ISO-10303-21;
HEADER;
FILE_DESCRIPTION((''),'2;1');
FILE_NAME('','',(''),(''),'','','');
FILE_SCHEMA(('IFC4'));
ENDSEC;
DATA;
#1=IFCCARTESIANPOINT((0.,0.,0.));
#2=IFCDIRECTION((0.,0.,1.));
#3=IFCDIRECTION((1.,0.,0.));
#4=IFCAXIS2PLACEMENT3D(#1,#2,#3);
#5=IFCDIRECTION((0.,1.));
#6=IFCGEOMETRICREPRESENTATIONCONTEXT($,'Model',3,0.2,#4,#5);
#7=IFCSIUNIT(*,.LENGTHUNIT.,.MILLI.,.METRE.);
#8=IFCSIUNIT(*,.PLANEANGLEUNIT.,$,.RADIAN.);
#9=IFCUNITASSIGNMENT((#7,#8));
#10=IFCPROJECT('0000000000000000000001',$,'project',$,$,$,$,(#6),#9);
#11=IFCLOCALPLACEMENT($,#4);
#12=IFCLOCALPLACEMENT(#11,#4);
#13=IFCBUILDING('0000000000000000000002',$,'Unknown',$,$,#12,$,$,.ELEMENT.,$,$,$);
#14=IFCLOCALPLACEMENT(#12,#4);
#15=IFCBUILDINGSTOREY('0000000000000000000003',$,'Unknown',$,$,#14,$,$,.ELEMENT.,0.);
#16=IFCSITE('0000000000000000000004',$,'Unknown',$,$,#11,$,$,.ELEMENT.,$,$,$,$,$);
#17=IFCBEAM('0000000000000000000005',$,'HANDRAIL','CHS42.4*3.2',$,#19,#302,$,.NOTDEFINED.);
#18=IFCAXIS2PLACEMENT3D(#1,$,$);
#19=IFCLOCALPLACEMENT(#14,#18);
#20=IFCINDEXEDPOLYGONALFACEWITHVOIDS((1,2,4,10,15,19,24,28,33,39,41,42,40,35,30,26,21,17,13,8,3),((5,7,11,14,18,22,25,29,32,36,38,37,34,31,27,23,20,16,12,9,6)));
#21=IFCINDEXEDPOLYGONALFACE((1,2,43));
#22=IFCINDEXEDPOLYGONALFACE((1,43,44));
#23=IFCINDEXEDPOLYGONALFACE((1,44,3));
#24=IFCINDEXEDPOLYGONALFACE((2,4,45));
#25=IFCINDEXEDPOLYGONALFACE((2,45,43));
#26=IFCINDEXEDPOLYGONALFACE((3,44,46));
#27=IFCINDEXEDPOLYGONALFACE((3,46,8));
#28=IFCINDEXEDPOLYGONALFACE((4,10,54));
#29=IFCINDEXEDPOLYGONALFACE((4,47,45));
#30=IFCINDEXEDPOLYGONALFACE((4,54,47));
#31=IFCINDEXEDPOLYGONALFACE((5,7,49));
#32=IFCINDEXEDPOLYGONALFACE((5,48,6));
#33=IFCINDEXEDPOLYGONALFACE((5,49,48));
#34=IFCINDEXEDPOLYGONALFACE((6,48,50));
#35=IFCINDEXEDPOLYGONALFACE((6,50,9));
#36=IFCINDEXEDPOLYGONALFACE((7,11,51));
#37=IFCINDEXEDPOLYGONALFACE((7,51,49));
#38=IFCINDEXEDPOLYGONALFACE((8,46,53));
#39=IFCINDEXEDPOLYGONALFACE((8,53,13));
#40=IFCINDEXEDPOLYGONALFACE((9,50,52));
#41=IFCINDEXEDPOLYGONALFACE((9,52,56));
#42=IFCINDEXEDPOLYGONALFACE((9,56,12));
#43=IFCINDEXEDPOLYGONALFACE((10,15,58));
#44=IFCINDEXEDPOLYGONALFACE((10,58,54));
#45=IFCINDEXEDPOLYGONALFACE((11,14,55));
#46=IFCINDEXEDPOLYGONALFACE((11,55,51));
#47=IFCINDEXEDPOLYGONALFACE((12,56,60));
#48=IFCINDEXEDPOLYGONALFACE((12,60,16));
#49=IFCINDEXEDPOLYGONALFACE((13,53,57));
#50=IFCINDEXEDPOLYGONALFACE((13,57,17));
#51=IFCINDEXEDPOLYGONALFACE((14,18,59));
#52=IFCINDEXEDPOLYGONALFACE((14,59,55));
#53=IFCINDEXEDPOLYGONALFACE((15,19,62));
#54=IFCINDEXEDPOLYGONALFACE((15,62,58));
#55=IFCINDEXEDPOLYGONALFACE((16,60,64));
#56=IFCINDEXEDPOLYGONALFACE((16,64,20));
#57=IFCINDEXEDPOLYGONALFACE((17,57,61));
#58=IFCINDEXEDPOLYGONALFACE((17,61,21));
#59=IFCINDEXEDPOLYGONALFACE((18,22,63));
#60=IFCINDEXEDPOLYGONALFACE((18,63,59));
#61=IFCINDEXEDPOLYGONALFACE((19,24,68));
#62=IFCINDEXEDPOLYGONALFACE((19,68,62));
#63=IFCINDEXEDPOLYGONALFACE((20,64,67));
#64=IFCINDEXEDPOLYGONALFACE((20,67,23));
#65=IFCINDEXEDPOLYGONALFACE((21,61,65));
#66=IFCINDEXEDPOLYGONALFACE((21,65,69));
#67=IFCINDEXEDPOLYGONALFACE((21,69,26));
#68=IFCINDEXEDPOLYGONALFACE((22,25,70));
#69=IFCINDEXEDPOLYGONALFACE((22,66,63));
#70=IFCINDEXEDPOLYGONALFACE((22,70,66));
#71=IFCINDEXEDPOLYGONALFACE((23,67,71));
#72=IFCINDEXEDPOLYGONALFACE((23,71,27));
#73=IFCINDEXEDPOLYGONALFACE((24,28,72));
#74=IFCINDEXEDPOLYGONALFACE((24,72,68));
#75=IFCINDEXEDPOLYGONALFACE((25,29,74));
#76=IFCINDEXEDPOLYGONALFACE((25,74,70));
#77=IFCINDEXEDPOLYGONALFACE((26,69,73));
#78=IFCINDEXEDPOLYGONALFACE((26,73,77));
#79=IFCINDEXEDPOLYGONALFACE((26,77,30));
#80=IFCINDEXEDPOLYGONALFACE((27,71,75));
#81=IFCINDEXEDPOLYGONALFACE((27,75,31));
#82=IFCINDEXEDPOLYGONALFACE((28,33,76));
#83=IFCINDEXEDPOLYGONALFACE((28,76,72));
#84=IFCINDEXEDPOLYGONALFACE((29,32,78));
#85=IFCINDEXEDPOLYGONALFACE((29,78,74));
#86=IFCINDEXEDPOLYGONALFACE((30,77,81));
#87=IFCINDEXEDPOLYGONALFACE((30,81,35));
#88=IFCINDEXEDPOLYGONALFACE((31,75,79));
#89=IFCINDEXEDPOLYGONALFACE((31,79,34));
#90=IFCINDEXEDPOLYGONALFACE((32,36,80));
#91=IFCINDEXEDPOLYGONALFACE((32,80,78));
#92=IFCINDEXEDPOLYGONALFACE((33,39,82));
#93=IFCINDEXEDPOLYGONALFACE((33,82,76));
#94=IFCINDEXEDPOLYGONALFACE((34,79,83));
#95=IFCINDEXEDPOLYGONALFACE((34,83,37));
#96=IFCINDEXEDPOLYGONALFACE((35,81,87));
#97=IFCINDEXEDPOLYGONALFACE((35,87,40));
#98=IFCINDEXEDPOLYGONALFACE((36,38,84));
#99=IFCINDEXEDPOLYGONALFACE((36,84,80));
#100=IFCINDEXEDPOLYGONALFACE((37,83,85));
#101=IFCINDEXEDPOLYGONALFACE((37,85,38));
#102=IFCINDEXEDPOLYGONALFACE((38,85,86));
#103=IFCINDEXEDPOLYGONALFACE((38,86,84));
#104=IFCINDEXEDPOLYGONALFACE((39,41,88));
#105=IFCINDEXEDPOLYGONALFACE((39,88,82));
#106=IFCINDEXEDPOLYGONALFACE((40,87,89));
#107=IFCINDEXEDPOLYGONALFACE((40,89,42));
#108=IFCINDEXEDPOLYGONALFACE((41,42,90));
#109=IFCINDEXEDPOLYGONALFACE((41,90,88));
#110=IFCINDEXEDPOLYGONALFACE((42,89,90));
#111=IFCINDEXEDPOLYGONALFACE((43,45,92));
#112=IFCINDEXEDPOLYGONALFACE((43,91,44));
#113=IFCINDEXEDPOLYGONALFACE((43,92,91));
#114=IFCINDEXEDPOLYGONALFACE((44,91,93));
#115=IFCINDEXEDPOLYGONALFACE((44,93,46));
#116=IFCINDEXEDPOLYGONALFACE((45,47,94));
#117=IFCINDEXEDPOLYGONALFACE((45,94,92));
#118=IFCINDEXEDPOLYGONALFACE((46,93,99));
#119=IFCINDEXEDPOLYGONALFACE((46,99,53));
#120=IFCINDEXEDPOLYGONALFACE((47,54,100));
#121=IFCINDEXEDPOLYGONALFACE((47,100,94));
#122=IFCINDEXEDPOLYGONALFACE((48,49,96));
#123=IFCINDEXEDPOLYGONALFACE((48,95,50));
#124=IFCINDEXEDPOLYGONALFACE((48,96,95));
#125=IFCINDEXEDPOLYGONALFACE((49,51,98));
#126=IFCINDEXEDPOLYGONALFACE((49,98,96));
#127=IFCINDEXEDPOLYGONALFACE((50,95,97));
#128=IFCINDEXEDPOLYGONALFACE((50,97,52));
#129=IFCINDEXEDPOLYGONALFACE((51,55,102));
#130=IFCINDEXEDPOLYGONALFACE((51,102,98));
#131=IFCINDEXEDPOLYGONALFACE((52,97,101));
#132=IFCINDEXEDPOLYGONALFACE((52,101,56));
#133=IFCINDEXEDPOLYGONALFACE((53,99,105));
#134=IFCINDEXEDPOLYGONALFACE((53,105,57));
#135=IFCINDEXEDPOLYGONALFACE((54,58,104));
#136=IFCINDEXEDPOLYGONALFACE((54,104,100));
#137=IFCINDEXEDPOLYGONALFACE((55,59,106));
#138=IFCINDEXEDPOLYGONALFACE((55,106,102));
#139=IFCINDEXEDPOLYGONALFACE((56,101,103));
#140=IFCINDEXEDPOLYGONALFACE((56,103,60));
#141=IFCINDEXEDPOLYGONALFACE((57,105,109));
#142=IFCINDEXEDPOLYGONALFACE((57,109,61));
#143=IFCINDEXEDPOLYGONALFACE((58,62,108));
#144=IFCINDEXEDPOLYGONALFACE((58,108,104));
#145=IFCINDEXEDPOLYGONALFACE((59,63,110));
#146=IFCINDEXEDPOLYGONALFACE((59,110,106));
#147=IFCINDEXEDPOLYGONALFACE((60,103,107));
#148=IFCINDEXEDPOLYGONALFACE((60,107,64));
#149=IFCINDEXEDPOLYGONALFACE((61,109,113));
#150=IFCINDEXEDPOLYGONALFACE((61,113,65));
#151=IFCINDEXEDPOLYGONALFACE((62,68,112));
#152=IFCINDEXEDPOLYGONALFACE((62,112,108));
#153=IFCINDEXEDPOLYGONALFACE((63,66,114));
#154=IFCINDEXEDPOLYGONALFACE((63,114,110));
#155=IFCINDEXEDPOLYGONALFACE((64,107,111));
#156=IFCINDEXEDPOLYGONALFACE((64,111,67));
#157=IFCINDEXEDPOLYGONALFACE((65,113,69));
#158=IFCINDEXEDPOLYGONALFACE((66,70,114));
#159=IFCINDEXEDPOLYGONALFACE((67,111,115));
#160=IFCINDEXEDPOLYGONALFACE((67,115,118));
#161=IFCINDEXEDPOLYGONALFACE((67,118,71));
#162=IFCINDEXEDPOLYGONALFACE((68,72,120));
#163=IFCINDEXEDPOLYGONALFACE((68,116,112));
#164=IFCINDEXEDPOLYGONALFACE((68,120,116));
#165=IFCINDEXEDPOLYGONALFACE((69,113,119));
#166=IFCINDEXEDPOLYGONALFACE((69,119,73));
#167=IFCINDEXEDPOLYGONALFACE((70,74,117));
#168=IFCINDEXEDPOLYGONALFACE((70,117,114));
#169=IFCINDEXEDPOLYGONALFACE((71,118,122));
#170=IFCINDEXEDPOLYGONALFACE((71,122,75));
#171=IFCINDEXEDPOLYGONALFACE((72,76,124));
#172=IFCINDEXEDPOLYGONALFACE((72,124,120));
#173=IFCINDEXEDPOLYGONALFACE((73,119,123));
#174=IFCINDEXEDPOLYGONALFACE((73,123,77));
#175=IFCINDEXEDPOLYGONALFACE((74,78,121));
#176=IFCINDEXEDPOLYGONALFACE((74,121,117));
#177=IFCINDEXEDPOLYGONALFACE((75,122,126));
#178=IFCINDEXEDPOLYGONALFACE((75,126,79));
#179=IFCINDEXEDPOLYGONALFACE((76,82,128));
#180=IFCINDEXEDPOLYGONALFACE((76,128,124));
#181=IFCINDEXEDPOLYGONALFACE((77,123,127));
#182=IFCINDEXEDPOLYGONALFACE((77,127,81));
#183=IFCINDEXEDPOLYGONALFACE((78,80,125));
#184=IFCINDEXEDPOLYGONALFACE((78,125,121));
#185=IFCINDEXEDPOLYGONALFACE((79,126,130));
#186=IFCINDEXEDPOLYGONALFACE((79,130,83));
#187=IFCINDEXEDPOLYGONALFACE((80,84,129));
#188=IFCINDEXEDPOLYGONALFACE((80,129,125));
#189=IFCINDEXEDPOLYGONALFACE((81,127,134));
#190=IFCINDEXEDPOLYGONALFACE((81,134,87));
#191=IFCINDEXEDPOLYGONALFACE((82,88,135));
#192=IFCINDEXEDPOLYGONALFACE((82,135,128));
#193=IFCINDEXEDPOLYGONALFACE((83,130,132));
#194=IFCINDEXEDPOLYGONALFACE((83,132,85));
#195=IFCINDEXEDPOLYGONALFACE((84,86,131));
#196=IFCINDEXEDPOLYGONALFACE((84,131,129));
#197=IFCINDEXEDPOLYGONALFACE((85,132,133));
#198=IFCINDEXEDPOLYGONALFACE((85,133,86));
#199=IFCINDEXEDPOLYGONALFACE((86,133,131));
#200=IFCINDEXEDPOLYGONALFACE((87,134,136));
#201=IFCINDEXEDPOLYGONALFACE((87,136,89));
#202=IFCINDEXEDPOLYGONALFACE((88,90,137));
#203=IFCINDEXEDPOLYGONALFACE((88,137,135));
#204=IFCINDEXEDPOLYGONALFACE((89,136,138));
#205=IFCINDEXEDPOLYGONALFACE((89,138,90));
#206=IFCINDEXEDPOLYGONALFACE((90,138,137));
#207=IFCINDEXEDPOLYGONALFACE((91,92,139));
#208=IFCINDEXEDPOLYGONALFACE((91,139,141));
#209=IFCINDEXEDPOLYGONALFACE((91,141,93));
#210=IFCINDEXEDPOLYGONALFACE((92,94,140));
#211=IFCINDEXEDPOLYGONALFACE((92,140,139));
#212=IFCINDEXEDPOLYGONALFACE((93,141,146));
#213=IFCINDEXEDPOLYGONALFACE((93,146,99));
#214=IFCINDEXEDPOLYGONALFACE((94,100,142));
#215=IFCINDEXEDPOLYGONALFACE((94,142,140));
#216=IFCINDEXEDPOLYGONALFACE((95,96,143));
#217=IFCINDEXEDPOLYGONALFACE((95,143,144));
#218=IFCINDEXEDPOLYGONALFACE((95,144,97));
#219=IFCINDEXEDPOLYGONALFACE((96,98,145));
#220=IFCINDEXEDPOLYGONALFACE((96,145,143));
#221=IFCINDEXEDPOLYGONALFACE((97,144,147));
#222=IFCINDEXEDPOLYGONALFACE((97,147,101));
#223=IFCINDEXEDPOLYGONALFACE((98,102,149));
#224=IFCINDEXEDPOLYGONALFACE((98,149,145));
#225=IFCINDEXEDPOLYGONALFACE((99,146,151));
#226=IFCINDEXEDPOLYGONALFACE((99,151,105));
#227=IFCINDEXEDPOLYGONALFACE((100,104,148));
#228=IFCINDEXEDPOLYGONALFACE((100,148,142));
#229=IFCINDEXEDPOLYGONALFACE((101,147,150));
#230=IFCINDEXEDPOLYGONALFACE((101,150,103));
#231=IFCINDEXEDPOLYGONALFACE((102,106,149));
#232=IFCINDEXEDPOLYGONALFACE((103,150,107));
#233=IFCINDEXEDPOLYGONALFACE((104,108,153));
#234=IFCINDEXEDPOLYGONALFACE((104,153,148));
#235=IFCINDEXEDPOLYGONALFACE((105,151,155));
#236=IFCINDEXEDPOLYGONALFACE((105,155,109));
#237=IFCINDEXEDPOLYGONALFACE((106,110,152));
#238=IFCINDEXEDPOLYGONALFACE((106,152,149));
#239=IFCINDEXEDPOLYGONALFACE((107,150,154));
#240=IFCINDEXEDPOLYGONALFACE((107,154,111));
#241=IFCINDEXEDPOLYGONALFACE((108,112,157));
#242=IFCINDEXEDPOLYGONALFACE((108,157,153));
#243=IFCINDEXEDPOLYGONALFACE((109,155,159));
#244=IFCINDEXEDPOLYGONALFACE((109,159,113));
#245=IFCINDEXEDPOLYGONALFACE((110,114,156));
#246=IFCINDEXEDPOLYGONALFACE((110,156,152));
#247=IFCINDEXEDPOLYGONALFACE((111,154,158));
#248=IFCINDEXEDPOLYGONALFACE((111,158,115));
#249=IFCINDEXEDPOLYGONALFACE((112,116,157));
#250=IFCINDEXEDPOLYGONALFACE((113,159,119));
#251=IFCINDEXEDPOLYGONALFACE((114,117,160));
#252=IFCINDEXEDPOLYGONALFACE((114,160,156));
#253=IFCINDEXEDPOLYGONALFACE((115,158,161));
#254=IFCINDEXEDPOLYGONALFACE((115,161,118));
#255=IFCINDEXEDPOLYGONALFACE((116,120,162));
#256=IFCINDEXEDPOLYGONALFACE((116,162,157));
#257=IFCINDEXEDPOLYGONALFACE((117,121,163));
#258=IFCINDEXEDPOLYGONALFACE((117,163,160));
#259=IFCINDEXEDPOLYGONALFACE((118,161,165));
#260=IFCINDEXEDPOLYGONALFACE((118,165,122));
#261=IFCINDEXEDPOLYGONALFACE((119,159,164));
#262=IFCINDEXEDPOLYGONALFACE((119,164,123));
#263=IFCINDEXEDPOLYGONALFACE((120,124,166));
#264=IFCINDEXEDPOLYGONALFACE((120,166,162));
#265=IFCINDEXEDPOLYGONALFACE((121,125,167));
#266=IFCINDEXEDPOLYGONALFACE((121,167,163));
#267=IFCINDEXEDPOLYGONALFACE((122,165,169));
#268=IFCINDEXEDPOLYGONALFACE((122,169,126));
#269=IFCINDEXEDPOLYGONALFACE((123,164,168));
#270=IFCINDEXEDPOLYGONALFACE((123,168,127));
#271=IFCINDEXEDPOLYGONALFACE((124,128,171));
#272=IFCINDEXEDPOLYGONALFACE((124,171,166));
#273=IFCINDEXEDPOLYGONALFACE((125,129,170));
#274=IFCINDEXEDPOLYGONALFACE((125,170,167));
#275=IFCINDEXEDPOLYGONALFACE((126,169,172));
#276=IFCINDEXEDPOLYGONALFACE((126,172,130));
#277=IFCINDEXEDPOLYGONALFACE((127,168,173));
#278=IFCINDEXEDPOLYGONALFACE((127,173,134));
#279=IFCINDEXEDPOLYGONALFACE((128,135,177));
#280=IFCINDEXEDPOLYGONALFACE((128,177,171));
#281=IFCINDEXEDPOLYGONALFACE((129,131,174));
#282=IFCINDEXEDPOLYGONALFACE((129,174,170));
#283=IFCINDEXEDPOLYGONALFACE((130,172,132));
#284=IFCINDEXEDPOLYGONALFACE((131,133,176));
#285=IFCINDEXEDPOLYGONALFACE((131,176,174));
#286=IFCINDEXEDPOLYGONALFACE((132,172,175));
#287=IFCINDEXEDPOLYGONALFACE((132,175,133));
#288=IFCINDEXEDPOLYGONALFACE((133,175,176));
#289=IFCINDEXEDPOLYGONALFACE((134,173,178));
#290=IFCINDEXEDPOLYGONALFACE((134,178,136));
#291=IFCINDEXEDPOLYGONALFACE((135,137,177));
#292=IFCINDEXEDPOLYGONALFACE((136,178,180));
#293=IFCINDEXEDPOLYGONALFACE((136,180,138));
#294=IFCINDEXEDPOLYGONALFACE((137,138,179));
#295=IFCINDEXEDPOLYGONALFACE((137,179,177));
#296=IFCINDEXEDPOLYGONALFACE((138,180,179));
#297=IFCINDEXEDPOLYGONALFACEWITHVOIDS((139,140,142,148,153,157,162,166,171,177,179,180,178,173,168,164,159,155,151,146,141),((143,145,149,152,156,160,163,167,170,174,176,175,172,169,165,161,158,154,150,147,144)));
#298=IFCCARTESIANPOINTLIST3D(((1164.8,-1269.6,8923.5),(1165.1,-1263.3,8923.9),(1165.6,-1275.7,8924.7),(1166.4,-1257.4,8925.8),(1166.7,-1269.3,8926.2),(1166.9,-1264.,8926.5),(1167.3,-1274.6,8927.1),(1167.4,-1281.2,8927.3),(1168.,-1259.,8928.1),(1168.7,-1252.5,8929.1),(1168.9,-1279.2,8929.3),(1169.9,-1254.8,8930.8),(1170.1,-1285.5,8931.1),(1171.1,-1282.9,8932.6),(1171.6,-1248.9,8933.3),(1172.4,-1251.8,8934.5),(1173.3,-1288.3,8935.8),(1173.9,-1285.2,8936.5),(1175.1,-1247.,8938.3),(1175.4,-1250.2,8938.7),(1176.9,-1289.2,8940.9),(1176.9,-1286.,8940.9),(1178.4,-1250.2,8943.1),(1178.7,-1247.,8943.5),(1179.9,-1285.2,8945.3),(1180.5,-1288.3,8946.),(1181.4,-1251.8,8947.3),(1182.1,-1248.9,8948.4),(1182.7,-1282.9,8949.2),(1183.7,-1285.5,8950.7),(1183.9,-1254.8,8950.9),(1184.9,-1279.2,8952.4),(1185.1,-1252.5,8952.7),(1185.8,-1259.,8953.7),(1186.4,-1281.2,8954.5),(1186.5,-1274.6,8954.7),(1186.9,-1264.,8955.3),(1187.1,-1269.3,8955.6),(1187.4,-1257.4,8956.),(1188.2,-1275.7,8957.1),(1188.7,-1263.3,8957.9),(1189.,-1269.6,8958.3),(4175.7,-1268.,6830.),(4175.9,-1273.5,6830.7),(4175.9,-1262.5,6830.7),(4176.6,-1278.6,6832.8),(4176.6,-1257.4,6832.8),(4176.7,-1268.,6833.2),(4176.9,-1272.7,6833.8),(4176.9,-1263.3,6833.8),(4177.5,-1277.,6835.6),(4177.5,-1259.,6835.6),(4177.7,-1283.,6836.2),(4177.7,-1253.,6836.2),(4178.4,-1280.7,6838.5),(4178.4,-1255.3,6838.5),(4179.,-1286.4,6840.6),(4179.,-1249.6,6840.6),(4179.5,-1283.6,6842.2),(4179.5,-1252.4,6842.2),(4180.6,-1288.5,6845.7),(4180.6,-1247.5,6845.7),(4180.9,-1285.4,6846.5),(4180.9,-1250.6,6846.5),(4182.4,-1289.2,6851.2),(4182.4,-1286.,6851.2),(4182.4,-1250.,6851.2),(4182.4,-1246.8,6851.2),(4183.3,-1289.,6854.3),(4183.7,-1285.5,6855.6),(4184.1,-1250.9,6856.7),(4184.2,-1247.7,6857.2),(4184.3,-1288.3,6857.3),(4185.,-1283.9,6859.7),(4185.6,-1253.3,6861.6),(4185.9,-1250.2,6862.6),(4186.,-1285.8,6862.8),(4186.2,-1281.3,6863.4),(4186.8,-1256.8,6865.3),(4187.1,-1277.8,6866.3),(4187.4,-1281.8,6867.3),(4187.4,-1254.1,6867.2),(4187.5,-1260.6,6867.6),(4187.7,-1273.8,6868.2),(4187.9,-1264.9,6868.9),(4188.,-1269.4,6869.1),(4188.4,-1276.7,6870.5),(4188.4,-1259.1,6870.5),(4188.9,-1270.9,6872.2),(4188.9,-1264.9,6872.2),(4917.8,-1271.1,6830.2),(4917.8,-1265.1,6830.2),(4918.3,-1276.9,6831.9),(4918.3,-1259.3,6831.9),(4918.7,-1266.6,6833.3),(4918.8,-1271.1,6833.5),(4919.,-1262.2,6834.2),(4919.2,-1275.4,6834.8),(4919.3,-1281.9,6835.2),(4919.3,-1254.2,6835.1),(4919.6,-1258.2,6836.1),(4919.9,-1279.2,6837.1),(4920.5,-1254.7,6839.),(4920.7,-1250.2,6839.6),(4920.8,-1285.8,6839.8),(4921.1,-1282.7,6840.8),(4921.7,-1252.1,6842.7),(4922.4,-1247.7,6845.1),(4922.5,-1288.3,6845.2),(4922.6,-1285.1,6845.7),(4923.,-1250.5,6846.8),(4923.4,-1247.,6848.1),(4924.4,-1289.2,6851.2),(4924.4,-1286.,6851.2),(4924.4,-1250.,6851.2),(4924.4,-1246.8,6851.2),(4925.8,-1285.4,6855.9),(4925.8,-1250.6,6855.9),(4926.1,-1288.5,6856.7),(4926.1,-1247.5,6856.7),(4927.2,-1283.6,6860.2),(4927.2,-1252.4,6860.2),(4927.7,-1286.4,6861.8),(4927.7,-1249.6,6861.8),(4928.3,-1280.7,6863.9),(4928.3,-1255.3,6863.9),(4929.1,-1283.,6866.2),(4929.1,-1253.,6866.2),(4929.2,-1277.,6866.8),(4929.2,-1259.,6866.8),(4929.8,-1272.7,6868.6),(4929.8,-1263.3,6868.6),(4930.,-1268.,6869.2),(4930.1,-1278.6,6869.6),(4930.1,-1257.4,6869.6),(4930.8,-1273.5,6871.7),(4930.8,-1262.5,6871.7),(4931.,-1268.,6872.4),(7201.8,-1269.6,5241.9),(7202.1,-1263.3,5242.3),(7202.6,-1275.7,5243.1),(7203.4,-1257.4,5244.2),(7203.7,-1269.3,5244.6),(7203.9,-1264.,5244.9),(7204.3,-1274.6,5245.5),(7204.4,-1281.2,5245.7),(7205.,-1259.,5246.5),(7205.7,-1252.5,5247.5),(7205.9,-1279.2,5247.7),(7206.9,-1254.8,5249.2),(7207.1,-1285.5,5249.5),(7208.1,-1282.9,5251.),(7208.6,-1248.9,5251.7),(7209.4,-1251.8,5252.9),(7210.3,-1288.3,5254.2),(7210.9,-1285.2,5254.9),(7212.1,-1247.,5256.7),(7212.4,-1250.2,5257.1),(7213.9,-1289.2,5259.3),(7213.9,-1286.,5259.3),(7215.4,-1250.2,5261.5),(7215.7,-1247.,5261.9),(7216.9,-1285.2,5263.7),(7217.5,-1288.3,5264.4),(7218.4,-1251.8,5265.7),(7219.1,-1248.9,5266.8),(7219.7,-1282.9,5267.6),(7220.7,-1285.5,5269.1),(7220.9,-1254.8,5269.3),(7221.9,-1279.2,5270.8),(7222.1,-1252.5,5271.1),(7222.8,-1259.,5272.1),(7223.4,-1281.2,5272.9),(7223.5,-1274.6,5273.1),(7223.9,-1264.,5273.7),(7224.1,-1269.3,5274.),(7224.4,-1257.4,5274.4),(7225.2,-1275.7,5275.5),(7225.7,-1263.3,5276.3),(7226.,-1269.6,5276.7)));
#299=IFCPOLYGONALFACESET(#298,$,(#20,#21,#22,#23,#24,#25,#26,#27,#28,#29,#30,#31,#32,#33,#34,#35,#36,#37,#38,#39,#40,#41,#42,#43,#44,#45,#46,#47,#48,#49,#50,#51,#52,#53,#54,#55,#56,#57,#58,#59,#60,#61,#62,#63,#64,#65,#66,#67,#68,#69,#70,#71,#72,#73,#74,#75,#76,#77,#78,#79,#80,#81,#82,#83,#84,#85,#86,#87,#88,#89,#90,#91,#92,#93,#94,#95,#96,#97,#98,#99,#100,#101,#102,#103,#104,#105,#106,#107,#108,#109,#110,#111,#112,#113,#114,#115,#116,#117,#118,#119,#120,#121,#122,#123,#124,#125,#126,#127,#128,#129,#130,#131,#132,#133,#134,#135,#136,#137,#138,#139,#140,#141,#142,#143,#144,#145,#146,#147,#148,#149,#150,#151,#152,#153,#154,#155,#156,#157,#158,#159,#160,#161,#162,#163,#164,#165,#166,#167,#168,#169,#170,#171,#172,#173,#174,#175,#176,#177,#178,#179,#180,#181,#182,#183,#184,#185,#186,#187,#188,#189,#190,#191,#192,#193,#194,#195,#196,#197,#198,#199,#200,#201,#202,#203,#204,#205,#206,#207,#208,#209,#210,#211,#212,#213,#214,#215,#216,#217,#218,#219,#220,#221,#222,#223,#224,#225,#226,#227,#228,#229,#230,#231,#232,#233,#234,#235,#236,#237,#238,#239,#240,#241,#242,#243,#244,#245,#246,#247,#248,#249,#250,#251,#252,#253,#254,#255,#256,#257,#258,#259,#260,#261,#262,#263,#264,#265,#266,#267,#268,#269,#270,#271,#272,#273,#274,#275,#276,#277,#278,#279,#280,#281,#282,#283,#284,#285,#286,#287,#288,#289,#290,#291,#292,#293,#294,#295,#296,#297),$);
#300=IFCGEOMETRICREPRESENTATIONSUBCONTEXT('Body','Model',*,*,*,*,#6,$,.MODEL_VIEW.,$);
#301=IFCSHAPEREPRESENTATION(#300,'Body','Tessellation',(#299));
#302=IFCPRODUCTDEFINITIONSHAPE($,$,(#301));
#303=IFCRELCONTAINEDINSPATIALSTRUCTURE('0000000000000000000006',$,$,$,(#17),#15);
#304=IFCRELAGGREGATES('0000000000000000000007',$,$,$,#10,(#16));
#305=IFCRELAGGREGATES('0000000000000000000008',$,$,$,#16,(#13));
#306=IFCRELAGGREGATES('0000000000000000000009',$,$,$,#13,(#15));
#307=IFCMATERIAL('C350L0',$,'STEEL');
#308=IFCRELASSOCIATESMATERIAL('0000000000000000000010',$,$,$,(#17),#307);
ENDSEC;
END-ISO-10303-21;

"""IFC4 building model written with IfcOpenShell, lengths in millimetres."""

from ifc_helpers import new_model, entity, si_unit, direction, frame, origin_with_axes, place, context, subcontext, project, spatial, material, element, save


model = new_model("IFC4")

# Units and contexts
model_context = context("Model", 3, precision=0.2, world=origin_with_axes(), true_north=direction((0.0, 1.0)))
body_context = subcontext(model_context, "Body", "Model", "MODEL_VIEW")
ifc_project = project(units=[si_unit("LENGTHUNIT", "METRE", prefix="MILLI"), si_unit("PLANEANGLEUNIT", "RADIAN")], contexts=[model_context])

# Site, building, storey
site_placement = place(None, origin_with_axes())
site = spatial("IfcSite", under=ifc_project, at=site_placement, Name="Unknown", CompositionType="ELEMENT")
building_placement = place(site_placement, origin_with_axes())
building = spatial("IfcBuilding", under=site, at=building_placement, Name="Unknown", CompositionType="ELEMENT")
storey_placement = place(building_placement, origin_with_axes())
storey = spatial("IfcBuildingStorey", under=building, at=storey_placement, Name="Unknown", CompositionType="ELEMENT", Elevation=0.0)

# Shared definitions
ifc_material_1 = material(Name="C350L0", Category="STEEL")

# Beam
for number, where, z_axis, x_axis, name in (
    (1, (1176.9, -1268.0, 8940.9), (0.0, -1.0, 0.0), (0.821041, 0.0, -0.57087), "HANDRAIL"),
):
    element("IfcBeam", number, at=place(storey_placement, frame(where, z_axis=z_axis, x_axis=x_axis)), inside=storey, material=ifc_material_1, Name=name, Description="CHS42.4*3.2", PredefinedType="NOTDEFINED", context=body_context, shape_type="SolidModel", body=[
        entity("IfcSweptDiskSolid", entity("IfcIndexedPolyCurve", entity("IfcCartesianPointList3D", [[0.0, 0.0, 0.0], [3660.5, 0.0, 0.0], [4269.8, 423.6, 0.0], [7058.3, 423.6, 0.0]]), [entity("IfcLineIndex", [1, 2, 3, 4])]), 21.2, 18.0),
    ])

save(model, "model.ifc")
